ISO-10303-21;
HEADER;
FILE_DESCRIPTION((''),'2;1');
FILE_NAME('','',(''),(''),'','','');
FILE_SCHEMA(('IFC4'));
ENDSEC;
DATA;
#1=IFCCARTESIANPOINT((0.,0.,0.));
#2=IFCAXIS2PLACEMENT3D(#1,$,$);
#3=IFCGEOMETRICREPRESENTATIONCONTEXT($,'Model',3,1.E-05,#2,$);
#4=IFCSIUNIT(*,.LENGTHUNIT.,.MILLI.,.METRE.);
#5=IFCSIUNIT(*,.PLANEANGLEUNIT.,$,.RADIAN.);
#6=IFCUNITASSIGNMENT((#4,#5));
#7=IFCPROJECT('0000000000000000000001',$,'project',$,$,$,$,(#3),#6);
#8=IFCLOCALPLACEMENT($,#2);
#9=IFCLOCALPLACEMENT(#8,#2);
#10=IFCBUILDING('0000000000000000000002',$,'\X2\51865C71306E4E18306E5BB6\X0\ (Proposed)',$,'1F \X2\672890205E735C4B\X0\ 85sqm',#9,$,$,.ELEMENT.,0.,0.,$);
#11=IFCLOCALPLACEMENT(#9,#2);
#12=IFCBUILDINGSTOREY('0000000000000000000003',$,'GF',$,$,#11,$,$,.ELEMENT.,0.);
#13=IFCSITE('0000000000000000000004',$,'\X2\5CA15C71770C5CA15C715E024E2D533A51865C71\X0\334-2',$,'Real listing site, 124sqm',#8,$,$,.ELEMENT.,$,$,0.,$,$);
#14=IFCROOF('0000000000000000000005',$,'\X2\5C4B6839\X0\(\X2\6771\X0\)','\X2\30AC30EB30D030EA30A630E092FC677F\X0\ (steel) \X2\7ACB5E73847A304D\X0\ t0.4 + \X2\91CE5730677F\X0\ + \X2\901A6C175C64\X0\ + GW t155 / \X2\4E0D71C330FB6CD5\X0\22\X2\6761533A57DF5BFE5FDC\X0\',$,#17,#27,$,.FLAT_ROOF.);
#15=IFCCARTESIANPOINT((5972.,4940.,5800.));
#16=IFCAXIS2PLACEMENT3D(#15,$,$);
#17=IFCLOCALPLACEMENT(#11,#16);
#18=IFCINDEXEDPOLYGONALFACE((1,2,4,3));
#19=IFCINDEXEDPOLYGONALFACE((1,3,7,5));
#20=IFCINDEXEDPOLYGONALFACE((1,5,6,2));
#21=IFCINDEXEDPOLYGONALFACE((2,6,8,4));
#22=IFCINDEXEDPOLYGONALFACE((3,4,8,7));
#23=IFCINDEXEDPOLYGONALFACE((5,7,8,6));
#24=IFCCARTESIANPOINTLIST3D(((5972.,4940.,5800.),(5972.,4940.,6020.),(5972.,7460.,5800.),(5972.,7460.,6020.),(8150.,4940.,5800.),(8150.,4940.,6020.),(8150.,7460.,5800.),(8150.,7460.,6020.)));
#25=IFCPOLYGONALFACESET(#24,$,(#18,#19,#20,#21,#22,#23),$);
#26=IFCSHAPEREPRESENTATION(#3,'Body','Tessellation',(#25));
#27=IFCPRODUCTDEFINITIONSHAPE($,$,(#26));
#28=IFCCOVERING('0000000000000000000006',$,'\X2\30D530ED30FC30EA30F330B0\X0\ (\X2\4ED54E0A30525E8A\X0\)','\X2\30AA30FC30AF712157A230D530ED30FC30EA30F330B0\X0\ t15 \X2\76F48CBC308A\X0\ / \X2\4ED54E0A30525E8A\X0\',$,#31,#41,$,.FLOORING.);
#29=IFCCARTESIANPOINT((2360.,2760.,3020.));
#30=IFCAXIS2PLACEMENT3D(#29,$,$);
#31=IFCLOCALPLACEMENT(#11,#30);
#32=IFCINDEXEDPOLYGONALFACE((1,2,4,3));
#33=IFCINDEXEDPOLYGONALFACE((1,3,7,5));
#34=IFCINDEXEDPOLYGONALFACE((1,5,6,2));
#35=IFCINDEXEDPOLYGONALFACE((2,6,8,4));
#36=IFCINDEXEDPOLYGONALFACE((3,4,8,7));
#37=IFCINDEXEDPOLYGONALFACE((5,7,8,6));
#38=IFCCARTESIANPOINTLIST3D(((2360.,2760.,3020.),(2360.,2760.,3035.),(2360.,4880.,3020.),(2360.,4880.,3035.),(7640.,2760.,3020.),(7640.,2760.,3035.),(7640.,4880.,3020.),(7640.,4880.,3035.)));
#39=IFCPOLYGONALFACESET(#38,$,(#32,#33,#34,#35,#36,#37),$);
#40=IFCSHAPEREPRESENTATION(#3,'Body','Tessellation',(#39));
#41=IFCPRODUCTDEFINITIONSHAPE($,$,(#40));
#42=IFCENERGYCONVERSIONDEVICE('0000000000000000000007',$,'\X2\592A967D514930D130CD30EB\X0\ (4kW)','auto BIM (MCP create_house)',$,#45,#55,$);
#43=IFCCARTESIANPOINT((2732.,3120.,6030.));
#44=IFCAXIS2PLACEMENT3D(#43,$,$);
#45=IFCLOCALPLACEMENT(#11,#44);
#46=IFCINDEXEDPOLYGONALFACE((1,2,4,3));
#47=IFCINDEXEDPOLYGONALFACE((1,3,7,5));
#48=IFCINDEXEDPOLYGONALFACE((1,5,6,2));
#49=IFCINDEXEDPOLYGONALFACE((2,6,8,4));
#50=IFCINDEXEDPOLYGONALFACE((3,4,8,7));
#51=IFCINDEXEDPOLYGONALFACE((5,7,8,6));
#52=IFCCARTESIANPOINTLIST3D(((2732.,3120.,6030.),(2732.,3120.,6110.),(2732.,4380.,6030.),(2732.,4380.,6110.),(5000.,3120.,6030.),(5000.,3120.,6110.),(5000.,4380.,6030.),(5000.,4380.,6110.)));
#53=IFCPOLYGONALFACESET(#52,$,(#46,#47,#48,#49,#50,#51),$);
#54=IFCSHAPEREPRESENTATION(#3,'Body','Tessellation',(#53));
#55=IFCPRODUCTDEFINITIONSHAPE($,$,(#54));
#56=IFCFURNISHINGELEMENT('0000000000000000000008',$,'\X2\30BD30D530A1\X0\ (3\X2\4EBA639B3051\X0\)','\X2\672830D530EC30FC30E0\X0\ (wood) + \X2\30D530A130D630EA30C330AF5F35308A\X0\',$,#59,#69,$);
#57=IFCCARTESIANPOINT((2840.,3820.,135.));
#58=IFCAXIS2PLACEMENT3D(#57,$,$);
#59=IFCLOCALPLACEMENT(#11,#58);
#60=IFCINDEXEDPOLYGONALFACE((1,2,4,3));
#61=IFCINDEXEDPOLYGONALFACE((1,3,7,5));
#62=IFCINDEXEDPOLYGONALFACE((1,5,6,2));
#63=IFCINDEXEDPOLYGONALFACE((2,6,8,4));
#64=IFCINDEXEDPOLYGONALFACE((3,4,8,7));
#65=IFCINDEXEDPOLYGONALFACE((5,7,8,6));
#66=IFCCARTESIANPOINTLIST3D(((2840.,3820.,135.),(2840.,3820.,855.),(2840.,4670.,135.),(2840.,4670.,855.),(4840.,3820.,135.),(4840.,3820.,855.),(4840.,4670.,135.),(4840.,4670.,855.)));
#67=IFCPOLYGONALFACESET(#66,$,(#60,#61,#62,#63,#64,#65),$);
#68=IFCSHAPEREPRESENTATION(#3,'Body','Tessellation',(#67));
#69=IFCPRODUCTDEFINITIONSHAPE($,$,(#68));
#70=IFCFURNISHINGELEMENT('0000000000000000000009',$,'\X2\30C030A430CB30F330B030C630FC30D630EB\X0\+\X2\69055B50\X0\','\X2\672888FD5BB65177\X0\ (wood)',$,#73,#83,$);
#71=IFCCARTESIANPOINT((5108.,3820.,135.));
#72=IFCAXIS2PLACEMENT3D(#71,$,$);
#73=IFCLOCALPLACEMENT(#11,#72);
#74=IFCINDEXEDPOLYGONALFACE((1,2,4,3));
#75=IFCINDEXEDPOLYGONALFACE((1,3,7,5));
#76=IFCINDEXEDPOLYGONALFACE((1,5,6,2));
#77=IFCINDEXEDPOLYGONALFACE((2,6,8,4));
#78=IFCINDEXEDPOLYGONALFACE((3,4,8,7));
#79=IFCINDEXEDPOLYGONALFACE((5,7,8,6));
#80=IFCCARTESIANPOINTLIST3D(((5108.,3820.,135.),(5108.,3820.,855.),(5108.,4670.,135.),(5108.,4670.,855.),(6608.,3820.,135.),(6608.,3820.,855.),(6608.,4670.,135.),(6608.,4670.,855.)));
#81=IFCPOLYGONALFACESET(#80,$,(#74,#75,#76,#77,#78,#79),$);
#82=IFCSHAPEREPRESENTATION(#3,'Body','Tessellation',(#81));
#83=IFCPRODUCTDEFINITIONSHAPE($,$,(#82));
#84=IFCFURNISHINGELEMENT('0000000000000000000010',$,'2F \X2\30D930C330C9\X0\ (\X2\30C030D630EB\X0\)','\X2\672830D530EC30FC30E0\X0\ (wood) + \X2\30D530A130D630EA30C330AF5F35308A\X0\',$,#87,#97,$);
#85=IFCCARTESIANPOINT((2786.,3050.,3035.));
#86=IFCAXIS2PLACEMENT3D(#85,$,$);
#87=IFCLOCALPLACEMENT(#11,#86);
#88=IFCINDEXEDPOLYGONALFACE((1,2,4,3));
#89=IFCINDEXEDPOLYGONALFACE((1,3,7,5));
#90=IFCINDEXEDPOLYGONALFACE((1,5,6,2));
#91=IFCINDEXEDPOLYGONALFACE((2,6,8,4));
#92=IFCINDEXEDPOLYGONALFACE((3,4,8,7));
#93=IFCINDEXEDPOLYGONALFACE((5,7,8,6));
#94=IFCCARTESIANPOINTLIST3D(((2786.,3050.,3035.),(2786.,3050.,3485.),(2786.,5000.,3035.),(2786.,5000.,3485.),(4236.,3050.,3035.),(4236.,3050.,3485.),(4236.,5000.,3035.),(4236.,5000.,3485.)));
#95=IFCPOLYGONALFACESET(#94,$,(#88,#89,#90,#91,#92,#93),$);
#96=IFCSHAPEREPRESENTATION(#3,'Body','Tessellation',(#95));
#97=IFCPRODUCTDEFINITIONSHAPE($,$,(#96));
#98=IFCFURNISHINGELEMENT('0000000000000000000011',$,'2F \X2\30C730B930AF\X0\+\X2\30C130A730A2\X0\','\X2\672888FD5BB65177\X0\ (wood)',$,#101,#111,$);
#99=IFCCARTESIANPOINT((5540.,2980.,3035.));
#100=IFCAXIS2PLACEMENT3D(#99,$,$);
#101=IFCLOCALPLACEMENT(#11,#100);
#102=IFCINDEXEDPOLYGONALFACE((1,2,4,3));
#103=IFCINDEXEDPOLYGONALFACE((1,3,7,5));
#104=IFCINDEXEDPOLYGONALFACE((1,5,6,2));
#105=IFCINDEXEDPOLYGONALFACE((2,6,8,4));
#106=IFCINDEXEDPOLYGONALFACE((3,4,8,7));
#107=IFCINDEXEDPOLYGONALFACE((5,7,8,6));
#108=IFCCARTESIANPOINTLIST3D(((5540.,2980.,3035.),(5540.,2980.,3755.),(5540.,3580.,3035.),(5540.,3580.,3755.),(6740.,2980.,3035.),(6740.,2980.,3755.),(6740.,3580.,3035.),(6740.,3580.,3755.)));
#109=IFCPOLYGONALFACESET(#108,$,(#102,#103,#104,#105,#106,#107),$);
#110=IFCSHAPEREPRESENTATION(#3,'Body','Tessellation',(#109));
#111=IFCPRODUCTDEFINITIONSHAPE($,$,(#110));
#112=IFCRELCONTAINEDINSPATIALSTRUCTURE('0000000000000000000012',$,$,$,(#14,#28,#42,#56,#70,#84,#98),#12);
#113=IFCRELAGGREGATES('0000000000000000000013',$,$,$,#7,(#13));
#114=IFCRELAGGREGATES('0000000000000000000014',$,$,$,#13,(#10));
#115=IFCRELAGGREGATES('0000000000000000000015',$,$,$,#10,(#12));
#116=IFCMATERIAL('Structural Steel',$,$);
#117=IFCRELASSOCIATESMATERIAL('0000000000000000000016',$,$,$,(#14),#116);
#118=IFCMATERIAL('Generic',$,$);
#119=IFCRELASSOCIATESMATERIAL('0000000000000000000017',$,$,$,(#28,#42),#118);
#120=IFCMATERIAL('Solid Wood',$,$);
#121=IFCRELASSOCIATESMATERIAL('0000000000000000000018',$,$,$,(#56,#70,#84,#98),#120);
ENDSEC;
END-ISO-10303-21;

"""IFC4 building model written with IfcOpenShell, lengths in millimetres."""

from ifc_helpers import new_model, si_unit, frame, frame_2d, origin, place, context, project, spatial, rectangle, extrude, material, element, save


model = new_model("IFC4")

# Units and contexts
model_context = context("Model", 3, precision=1e-05, world=origin())
ifc_project = project(units=[si_unit("LENGTHUNIT", "METRE", prefix="MILLI"), si_unit("PLANEANGLEUNIT", "RADIAN")], contexts=[model_context])

# Site, building, storey
site_placement = place(None, origin())
site = spatial("IfcSite", under=ifc_project, at=site_placement, Name="岡山県岡山市中区円山334-2", ObjectType="Real listing site, 124sqm", CompositionType="ELEMENT", RefElevation=0.0)
building_placement = place(site_placement, origin())
building = spatial("IfcBuilding", under=site, at=building_placement, Name="円山の丘の家 (Proposed)", ObjectType="1F 木造平屋 85sqm", CompositionType="ELEMENT", ElevationOfRefHeight=0.0, ElevationOfTerrain=0.0)
storey_placement = place(building_placement, origin())
storey = spatial("IfcBuildingStorey", under=building, at=storey_placement, Name="GF", CompositionType="ELEMENT", Elevation=0.0)

# Shared definitions
ifc_material_1 = material(Name="Solid Wood")

# Roof
ifc_material_2 = material(Name="Structural Steel")
roof_1_placement = place(storey_placement, frame((5972.0, 4940.0, 5800.0)))
element("IfcRoof", 1, at=roof_1_placement, inside=storey, material=ifc_material_2, Name="屋根(東)", Description="ガルバリウム鋼板 (steel) 立平葺き t0.4 + 野地板 + 通気層 + GW t155 / 不燃・法22条区域対応", PredefinedType="FLAT_ROOF", context=model_context, shape_type="SweptSolid", body=[
    extrude(rectangle(XDim=2178.0, YDim=2520.0, at=frame_2d((1089.0, 1260.0))), frame((5972.0, 4940.0, 5800.0)), (0.0, 0.0, 1.0), 220.0),
])

# Covering
ifc_material_3 = material(Name="Generic")
covering_placement = place(storey_placement, frame((2360.0, 2760.0, 3020.0)))
element("IfcCovering", 2, at=covering_placement, inside=storey, material=ifc_material_3, Name="フローリング (仕上げ床)", Description="オーク無垢フローリング t15 直貼り / 仕上げ床", PredefinedType="FLOORING", context=model_context, shape_type="SweptSolid", body=[
    extrude(rectangle(XDim=5280.0, YDim=2120.0, at=frame_2d((2640.0, 1060.0))), frame((2360.0, 2760.0, 3020.0)), (0.0, 0.0, 1.0), 15.0),
])

# Energy conversion device
energy_conversion_device_placement = place(storey_placement, frame((2732.0, 3120.0, 6030.0)))
element("IfcEnergyConversionDevice", 3, at=energy_conversion_device_placement, inside=storey, material=ifc_material_3, Name="太陽光パネル (4kW)", Description="auto BIM (MCP create_house)", context=model_context, shape_type="SweptSolid", body=[
    extrude(rectangle(XDim=2268.0, YDim=1260.0, at=frame_2d((1134.0, 630.0))), frame((2732.0, 3120.0, 6030.0)), (0.0, 0.0, 1.0), 80.0),
])

# Furnishing elements
furnishing_1_placement = place(storey_placement, frame((2840.0, 3820.0, 135.0)))
element("IfcFurnishingElement", 4, at=furnishing_1_placement, inside=storey, material=ifc_material_1, Name="ソファ (3人掛け)", Description="木フレーム (wood) + ファブリック張り", context=model_context, shape_type="SweptSolid", body=[
    extrude(rectangle(XDim=2000.0, YDim=850.0, at=frame_2d((1000.0, 425.0))), frame((2840.0, 3820.0, 135.0)), (0.0, 0.0, 1.0), 720.0),
])
furnishing_2_placement = place(storey_placement, frame((5108.0, 3820.0, 135.0)))
element("IfcFurnishingElement", 5, at=furnishing_2_placement, inside=storey, material=ifc_material_1, Name="ダイニングテーブル+椅子", Description="木製家具 (wood)", context=model_context, shape_type="SweptSolid", body=[
    extrude(rectangle(XDim=1500.0, YDim=850.0, at=frame_2d((750.0, 425.0))), frame((5108.0, 3820.0, 135.0)), (0.0, 0.0, 1.0), 720.0),
])
furnishing_3_placement = place(storey_placement, frame((2786.0, 3050.0, 3035.0)))
element("IfcFurnishingElement", 6, at=furnishing_3_placement, inside=storey, material=ifc_material_1, Name="2F ベッド (ダブル)", Description="木フレーム (wood) + ファブリック張り", context=model_context, shape_type="SweptSolid", body=[
    extrude(rectangle(XDim=1450.0, YDim=1950.0, at=frame_2d((725.0, 975.0))), frame((2786.0, 3050.0, 3035.0)), (0.0, 0.0, 1.0), 450.0),
])
furnishing_4_placement = place(storey_placement, frame((5540.0, 2980.0, 3035.0)))
element("IfcFurnishingElement", 7, at=furnishing_4_placement, inside=storey, material=ifc_material_1, Name="2F デスク+チェア", Description="木製家具 (wood)", context=model_context, shape_type="SweptSolid", body=[
    extrude(rectangle(XDim=1200.0, YDim=600.0, at=frame_2d((600.0, 300.0))), frame((5540.0, 2980.0, 3035.0)), (0.0, 0.0, 1.0), 720.0),
])

save(model, "model.ifc")
